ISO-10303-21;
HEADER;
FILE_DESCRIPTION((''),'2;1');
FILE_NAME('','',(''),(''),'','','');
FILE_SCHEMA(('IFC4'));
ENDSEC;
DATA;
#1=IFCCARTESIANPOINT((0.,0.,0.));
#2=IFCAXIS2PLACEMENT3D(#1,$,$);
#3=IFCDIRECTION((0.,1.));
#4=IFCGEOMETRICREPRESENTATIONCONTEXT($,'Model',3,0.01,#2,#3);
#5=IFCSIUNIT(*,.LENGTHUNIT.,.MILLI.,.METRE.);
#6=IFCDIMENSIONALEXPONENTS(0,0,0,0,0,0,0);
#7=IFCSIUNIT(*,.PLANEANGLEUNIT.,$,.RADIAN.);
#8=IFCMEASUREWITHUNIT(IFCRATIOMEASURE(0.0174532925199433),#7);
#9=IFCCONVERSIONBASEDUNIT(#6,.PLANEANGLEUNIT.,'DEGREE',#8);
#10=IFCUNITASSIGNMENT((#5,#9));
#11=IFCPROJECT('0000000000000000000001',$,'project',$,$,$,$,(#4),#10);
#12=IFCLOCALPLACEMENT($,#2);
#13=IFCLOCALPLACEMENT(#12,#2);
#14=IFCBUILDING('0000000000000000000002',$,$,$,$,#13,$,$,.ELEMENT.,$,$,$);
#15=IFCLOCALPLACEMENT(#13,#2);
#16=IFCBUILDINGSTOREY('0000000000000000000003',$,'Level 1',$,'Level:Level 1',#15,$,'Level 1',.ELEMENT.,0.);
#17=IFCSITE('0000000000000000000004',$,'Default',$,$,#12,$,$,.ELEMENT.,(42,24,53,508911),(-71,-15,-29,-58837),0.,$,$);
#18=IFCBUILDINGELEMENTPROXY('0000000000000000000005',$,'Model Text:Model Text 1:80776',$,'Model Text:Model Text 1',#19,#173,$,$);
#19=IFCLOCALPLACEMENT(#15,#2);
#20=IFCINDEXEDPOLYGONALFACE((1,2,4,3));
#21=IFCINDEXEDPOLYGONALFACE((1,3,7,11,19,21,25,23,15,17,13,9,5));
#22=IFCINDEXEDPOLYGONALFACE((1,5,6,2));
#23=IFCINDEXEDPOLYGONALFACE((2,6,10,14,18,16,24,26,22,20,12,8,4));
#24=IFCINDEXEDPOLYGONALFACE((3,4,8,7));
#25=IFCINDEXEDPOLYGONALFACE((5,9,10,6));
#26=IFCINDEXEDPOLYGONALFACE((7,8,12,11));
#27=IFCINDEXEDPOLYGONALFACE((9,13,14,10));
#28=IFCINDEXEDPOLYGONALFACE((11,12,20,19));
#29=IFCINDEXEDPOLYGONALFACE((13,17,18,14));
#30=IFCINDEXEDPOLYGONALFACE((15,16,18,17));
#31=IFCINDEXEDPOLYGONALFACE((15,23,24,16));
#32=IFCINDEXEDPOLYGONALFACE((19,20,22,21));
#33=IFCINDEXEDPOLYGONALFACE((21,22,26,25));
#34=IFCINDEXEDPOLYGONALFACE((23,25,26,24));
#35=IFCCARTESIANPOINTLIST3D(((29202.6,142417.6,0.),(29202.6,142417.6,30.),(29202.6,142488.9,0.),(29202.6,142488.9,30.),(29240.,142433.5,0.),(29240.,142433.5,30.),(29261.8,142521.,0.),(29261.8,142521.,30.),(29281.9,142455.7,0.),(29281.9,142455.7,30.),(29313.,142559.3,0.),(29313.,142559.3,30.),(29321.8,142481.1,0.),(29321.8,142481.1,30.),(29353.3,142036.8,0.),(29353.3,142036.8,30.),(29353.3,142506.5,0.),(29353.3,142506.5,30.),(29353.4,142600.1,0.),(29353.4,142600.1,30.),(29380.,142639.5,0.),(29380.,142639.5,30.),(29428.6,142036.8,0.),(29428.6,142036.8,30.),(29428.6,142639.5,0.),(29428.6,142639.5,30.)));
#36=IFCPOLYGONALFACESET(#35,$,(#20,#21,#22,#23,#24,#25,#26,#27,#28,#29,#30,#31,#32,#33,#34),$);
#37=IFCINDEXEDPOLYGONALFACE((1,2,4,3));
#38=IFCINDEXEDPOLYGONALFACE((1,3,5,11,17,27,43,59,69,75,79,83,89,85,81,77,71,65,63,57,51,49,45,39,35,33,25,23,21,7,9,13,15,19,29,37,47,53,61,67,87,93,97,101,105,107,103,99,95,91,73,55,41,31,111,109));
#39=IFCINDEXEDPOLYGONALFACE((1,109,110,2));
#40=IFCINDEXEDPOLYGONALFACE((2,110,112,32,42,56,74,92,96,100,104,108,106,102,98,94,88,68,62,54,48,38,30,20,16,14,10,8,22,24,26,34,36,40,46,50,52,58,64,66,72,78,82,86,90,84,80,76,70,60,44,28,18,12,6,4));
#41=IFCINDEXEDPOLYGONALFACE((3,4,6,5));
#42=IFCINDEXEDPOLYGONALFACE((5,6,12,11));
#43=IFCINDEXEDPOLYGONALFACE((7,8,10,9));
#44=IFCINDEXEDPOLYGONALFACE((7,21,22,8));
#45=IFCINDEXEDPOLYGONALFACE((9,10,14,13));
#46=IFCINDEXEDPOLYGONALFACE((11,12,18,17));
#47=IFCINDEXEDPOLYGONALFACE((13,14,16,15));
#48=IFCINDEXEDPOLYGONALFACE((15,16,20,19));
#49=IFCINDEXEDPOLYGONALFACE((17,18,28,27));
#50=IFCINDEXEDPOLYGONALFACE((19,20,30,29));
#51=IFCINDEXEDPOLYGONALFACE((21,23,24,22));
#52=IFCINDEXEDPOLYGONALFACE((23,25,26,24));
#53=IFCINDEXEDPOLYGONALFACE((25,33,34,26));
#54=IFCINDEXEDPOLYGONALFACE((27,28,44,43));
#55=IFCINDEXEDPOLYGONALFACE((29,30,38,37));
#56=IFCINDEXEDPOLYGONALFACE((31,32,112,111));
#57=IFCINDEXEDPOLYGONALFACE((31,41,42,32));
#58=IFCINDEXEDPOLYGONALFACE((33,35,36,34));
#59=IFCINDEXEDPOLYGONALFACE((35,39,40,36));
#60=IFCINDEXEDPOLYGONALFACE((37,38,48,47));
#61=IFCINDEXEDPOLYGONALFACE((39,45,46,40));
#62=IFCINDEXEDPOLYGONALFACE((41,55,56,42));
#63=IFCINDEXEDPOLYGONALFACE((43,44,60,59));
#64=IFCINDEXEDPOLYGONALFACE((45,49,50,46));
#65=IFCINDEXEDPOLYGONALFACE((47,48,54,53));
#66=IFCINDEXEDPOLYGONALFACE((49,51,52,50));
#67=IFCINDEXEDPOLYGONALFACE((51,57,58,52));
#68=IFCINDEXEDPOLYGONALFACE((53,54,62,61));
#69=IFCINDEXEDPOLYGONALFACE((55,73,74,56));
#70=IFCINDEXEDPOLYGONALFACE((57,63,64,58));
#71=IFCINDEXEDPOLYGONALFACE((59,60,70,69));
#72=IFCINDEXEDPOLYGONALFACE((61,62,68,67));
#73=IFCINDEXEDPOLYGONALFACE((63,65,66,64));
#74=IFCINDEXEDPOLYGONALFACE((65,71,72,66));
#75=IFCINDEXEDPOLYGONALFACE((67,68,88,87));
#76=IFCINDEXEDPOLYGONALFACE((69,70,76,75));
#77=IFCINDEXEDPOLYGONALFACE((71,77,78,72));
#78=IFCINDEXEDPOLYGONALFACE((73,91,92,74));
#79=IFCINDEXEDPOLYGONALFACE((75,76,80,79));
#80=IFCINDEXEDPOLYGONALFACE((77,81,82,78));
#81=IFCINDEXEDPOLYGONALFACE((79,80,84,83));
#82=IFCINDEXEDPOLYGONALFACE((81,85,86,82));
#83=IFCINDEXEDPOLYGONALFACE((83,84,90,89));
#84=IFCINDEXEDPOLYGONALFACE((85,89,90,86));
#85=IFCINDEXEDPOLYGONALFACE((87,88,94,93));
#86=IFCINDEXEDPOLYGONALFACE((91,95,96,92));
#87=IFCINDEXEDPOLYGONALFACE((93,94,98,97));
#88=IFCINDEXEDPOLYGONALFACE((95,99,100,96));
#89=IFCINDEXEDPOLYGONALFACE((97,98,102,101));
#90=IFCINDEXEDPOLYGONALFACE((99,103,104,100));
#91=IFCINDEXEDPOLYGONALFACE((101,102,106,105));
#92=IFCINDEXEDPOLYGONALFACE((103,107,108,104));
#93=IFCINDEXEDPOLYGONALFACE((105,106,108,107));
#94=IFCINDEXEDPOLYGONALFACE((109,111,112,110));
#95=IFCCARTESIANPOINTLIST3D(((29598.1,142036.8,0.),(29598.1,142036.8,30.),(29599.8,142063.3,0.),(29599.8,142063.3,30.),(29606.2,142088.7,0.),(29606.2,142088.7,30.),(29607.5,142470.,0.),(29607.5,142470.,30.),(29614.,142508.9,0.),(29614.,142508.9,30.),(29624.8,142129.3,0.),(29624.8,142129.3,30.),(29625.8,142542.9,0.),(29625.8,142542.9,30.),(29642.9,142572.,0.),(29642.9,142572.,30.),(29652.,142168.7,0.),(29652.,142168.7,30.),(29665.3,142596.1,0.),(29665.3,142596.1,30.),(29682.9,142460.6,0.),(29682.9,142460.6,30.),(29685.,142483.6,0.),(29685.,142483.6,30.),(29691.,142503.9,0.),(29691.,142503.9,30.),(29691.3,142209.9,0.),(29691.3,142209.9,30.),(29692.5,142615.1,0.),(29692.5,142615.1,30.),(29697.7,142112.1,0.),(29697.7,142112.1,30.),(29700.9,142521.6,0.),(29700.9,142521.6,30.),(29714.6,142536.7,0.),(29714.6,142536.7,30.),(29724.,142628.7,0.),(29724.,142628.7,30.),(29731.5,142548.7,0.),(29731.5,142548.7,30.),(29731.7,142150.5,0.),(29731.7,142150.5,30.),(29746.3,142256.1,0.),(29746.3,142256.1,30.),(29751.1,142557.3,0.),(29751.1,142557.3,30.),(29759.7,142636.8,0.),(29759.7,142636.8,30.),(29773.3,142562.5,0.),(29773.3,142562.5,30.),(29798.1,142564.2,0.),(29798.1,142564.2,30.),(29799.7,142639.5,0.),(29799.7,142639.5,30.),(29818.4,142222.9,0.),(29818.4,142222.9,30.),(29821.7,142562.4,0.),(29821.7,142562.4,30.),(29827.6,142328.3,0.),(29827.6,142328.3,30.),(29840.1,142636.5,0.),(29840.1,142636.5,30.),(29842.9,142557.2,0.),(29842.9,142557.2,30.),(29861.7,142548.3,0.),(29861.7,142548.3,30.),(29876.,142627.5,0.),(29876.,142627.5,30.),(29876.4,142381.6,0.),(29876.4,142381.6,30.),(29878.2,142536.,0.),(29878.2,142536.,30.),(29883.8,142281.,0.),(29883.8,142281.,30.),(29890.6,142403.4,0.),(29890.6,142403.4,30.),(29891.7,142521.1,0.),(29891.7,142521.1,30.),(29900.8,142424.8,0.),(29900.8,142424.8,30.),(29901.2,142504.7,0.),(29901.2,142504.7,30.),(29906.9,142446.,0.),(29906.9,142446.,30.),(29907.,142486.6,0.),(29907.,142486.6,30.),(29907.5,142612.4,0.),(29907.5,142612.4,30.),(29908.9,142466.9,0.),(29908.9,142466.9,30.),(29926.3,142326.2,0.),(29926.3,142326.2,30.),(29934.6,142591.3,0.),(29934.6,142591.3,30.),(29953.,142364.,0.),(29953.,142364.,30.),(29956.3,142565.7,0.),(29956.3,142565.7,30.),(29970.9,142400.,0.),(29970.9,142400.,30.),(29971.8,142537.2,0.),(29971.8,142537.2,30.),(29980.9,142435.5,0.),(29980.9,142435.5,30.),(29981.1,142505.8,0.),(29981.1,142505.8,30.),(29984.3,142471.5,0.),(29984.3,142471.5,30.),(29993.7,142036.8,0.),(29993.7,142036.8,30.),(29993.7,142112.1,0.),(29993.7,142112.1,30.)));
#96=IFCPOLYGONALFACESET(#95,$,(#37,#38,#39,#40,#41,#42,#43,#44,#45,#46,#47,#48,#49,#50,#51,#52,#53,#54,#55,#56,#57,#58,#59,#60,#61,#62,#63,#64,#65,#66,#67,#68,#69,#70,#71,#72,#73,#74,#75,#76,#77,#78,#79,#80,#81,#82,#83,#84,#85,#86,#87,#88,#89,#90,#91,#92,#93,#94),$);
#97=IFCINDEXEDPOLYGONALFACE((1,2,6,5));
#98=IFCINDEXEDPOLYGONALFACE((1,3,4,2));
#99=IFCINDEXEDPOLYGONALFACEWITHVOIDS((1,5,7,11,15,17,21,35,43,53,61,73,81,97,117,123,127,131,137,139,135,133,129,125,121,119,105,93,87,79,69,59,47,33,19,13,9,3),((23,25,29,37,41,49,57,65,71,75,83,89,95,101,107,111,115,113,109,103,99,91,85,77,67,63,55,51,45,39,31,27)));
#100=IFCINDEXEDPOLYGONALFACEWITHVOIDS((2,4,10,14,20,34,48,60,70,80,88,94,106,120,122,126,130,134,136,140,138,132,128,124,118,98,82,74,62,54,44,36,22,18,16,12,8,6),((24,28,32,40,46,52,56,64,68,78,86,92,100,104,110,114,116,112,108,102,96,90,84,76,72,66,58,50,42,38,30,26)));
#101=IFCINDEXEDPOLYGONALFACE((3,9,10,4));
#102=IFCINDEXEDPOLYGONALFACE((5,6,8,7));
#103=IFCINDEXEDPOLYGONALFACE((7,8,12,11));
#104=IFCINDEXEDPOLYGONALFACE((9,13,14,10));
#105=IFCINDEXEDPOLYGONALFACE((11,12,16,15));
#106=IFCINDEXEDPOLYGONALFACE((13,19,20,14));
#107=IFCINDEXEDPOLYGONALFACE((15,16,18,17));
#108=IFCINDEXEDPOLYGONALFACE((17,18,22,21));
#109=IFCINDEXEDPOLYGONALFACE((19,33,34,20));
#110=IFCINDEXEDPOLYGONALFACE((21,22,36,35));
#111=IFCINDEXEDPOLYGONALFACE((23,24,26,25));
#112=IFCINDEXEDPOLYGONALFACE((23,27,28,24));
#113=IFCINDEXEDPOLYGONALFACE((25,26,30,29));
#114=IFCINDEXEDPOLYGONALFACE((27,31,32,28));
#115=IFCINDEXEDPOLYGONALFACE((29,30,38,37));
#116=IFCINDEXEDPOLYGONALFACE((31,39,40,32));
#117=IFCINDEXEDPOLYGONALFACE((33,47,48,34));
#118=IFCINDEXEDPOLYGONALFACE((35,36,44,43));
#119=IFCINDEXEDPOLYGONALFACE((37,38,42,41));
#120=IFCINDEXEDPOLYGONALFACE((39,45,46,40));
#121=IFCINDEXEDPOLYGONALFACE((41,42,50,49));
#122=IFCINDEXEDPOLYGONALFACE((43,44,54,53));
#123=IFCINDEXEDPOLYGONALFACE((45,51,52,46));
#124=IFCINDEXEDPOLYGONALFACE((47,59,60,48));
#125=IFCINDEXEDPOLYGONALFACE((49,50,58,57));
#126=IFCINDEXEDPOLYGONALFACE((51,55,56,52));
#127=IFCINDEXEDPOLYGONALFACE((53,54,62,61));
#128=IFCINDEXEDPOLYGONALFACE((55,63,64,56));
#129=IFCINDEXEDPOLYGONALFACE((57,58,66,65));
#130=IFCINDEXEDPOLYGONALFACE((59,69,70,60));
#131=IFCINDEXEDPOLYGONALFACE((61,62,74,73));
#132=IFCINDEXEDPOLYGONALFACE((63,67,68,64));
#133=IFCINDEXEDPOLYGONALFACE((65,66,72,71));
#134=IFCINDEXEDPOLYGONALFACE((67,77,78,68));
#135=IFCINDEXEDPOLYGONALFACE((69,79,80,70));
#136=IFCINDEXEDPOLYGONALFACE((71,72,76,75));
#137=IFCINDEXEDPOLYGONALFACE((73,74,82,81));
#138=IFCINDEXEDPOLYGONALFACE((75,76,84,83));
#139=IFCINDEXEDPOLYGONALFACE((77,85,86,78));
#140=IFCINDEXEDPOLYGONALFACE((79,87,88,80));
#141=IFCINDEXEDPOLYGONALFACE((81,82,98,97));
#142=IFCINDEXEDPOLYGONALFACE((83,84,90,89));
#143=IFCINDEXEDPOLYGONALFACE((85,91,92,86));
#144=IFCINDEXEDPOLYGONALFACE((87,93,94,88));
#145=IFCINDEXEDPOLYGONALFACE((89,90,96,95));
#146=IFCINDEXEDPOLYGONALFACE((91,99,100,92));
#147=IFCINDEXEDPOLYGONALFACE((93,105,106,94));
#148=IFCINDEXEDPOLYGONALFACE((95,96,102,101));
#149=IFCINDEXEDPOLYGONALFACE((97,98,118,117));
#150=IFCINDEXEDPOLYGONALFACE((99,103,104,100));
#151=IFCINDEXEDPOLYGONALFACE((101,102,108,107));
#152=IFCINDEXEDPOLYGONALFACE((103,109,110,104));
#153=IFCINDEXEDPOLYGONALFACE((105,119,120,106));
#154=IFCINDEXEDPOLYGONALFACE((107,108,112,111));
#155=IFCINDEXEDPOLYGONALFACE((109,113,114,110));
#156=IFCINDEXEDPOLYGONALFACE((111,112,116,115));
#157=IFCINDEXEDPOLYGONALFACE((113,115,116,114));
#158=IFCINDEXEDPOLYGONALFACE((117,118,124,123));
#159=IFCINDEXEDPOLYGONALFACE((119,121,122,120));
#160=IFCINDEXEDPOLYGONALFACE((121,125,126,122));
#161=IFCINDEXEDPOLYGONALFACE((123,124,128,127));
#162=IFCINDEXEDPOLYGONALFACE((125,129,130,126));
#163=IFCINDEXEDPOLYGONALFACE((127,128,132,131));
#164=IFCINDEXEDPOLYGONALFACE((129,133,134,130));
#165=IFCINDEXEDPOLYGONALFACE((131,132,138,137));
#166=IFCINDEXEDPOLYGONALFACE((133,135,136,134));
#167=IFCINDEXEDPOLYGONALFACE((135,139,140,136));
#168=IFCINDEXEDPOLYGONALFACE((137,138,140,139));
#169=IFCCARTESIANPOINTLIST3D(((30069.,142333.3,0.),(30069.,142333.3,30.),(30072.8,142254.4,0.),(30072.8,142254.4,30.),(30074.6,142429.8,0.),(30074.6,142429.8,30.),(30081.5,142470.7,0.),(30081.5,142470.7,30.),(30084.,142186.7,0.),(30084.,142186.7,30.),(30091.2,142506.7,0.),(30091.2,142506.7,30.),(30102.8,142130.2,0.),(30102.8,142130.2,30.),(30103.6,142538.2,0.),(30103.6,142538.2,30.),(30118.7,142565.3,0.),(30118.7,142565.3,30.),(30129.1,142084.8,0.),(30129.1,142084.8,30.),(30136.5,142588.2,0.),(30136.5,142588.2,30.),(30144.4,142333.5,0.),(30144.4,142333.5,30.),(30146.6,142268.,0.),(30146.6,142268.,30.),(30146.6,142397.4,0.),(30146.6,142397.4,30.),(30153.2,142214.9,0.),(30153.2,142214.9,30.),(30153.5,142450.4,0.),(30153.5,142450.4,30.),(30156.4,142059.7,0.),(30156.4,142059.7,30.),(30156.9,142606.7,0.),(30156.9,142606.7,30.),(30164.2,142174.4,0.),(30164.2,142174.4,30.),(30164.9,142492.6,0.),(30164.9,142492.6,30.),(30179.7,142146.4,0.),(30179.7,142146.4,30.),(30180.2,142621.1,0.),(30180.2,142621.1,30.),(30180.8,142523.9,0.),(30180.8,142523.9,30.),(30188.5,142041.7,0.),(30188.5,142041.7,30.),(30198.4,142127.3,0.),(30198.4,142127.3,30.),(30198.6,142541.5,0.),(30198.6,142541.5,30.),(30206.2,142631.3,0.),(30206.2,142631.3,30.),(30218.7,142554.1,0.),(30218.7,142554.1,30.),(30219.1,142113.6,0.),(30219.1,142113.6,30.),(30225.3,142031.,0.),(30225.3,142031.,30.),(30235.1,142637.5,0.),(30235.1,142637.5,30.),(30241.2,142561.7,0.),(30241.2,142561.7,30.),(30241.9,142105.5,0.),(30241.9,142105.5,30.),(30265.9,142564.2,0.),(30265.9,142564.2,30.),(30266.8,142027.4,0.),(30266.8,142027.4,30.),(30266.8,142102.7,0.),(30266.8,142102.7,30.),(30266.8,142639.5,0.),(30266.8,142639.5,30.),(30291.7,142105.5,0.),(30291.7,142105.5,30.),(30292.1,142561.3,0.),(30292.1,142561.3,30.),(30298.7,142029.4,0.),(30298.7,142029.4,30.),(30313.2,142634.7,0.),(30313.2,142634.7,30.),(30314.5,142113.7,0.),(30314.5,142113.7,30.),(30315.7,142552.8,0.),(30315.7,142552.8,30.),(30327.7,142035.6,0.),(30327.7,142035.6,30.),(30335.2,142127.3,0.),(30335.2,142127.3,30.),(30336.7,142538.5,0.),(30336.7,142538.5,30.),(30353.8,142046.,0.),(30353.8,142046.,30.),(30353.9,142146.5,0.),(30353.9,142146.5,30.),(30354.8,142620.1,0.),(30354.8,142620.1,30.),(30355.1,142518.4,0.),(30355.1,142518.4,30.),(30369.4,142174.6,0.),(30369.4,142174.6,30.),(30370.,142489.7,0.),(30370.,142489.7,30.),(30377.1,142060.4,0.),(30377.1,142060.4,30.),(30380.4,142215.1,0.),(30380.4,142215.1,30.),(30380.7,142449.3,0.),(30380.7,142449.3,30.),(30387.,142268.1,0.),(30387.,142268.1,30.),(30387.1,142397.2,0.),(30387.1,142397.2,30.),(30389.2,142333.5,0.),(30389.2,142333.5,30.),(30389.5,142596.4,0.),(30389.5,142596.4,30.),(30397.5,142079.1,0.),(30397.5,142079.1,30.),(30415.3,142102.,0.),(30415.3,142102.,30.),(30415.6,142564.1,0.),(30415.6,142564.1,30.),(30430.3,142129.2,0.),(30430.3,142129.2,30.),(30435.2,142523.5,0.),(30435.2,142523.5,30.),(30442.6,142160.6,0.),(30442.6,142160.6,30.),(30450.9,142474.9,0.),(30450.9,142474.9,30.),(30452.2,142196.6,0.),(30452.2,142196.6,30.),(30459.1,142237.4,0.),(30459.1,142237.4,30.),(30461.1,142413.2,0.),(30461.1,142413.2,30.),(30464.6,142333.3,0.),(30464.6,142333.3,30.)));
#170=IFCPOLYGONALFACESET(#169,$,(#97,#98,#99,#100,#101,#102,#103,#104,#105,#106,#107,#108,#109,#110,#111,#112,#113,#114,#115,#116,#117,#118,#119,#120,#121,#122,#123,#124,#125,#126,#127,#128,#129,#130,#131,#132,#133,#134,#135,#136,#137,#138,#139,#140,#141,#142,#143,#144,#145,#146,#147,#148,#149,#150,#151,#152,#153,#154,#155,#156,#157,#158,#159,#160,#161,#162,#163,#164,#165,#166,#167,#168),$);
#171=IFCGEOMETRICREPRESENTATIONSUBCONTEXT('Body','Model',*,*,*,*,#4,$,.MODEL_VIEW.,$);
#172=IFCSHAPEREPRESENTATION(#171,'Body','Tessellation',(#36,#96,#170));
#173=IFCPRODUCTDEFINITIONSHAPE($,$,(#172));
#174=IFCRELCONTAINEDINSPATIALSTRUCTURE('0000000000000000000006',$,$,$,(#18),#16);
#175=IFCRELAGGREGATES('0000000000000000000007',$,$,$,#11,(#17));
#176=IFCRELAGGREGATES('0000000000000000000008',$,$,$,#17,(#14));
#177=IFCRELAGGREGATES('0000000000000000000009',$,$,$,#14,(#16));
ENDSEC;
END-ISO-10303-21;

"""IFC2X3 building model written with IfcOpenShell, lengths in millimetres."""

from ifc_helpers import new_model, entity, si_unit, converted_unit, direction, frame, origin, place, context, subcontext, project, spatial, polyline, outline, extrude, element, save


model = new_model("IFC2X3")

# Units and contexts
model_context = context("Model", 3, precision=0.01, world=origin(), true_north=direction((0.0, 1.0)))
body_context = subcontext(model_context, "Body", "Model", "MODEL_VIEW")
ifc_project = project(units=[si_unit("LENGTHUNIT", "METRE", prefix="MILLI"), converted_unit("PLANEANGLEUNIT", "DEGREE", entity("IfcRatioMeasure", 0.0174532925199433), si_unit("PLANEANGLEUNIT", "RADIAN"), dimensions=[0, 0, 0, 0, 0, 0, 0])], contexts=[model_context])

# Site, building, storey
site_placement = place(None, origin())
site = spatial("IfcSite", under=ifc_project, at=site_placement, Name="Default", CompositionType="ELEMENT", RefLatitude=(42, 24, 53, 508911), RefLongitude=(-71, -15, -29, -58837), RefElevation=0.0)
building_placement = place(site_placement, origin())
building = spatial("IfcBuilding", under=site, at=building_placement, CompositionType="ELEMENT")
storey_placement = place(building_placement, origin())
storey = spatial("IfcBuildingStorey", under=building, at=storey_placement, Name="Level 1", ObjectType="Level:Level 1", LongName="Level 1", CompositionType="ELEMENT", Elevation=0.0)

# Building element proxy
proxy_1_placement = place(storey_placement, origin())
element("IfcBuildingElementProxy", 1, at=proxy_1_placement, inside=storey, Name="Model Text:Model Text 1:80776", ObjectType="Model Text:Model Text 1", context=body_context, shape_type="SweptSolid", body=[
    extrude(outline(polyline([(-410.6, -111.6), (192.1, -111.6), (192.1, -63.1), (152.7, -36.4), (111.9, 4.0), (73.6, 55.2), (41.4, 114.4), (-29.8, 114.4), (-13.9, 77.0), (8.3, 35.1), (33.7, -4.8), (59.1, -36.3), (-410.6, -36.3), (-410.6, -111.6)])), frame((29317.0, 142447.4, 0.0), z_axis=(0.0, 0.0, 1.0), x_axis=(0.0, 1.0, 0.0)), (0.0, 0.0, 1.0), 30.0),
    extrude(outline(polyline([(-190.2, -317.5), (-190.2, -392.8), (205.4, -392.8), (203.7, -366.3), (197.3, -340.9), (178.7, -300.3), (151.5, -260.9), (112.2, -219.7), (57.2, -173.6), (-24.1, -101.3), (-72.9, -48.0), (-87.1, -26.3), (-97.3, -4.8), (-103.4, 16.4), (-105.4, 37.3), (-103.5, 57.0), (-97.7, 75.0), (-88.2, 91.5), (-74.7, 106.4), (-58.2, 118.7), (-39.4, 127.5), (-18.2, 132.8), (5.4, 134.6), (30.2, 132.9), (52.4, 127.7), (72.0, 119.1), (88.9, 107.1), (102.6, 92.0), (112.5, 74.3), (118.5, 54.0), (120.6, 31.0), (196.0, 40.4), (189.5, 79.3), (177.7, 113.3), (160.6, 142.4), (138.2, 166.5), (111.0, 185.5), (79.5, 199.1), (43.8, 207.2), (3.8, 209.9), (-36.6, 206.9), (-72.5, 197.9), (-104.0, 182.8), (-131.1, 161.7), (-152.8, 136.1), (-168.3, 107.6), (-177.6, 76.2), (-180.8, 41.9), (-177.4, 5.8), (-167.4, -29.6), (-149.5, -65.6), (-122.8, -103.4), (-80.3, -148.6), (-14.9, -206.7), (71.8, -279.1), (105.8, -317.5), (-190.2, -317.5)])), frame((29803.5, 142429.6, 0.0), z_axis=(0.0, 0.0, -1.0), x_axis=(-1.0, 0.0, 0.0)), (0.0, 0.0, -1.0), 30.0),
    extrude(outline(polyline([(-10.6, -198.7), (68.3, -198.7), (136.5, -190.7), (193.9, -174.7), (240.5, -150.6), (266.9, -124.4), (286.3, -93.2), (298.8, -57.0), (304.3, -15.7), (303.8, 16.2), (299.0, 45.5), (289.9, 72.1), (276.6, 96.0), (258.9, 117.3), (236.9, 136.2), (210.4, 152.5), (179.6, 166.3), (144.1, 177.6), (103.7, 186.3), (8.2, 196.4), (-71.8, 196.7), (-134.0, 189.4), (-183.3, 176.1), (-224.7, 158.4), (-258.2, 133.9), (-283.5, 100.3), (-300.1, 59.5), (-307.1, 13.4), (-306.6, -18.4), (-301.8, -47.5), (-292.8, -74.0), (-279.6, -97.9), (-262.0, -119.2), (-240.0, -138.1), (-213.6, -154.5), (-182.8, -168.4), (-147.3, -179.8), (-106.7, -188.6), (-10.6, -198.7)]), holes=[polyline([(-7.2, -123.5), (-71.0, -118.2), (-123.6, -108.8), (-165.2, -95.4), (-195.7, -78.0), (-212.4, -59.4), (-224.1, -38.7), (-230.6, -15.9), (-231.9, 8.9), (-227.8, 35.0), (-218.1, 58.1), (-202.8, 78.4), (-182.0, 95.8), (-152.6, 109.4), (-111.7, 118.1), (-59.4, 122.0), (4.4, 121.1), (69.6, 115.8), (122.2, 106.7), (162.2, 93.7), (189.5, 77.0), (207.7, 57.4), (220.4, 36.0), (227.5, 12.8), (229.1, -12.1), (225.2, -36.8), (215.9, -59.2), (201.3, -79.3), (181.4, -97.1), (152.6, -111.2), (111.6, -120.3), (58.3, -124.4), (-7.2, -123.5)])]), frame((30268.0, 142332.1, 0.0), z_axis=(0.0, 0.0, 1.0), x_axis=(0.047515, -0.998871, 0.0)), (0.0, 0.0, 1.0), 30.0),
])

save(model, "model.ifc")
